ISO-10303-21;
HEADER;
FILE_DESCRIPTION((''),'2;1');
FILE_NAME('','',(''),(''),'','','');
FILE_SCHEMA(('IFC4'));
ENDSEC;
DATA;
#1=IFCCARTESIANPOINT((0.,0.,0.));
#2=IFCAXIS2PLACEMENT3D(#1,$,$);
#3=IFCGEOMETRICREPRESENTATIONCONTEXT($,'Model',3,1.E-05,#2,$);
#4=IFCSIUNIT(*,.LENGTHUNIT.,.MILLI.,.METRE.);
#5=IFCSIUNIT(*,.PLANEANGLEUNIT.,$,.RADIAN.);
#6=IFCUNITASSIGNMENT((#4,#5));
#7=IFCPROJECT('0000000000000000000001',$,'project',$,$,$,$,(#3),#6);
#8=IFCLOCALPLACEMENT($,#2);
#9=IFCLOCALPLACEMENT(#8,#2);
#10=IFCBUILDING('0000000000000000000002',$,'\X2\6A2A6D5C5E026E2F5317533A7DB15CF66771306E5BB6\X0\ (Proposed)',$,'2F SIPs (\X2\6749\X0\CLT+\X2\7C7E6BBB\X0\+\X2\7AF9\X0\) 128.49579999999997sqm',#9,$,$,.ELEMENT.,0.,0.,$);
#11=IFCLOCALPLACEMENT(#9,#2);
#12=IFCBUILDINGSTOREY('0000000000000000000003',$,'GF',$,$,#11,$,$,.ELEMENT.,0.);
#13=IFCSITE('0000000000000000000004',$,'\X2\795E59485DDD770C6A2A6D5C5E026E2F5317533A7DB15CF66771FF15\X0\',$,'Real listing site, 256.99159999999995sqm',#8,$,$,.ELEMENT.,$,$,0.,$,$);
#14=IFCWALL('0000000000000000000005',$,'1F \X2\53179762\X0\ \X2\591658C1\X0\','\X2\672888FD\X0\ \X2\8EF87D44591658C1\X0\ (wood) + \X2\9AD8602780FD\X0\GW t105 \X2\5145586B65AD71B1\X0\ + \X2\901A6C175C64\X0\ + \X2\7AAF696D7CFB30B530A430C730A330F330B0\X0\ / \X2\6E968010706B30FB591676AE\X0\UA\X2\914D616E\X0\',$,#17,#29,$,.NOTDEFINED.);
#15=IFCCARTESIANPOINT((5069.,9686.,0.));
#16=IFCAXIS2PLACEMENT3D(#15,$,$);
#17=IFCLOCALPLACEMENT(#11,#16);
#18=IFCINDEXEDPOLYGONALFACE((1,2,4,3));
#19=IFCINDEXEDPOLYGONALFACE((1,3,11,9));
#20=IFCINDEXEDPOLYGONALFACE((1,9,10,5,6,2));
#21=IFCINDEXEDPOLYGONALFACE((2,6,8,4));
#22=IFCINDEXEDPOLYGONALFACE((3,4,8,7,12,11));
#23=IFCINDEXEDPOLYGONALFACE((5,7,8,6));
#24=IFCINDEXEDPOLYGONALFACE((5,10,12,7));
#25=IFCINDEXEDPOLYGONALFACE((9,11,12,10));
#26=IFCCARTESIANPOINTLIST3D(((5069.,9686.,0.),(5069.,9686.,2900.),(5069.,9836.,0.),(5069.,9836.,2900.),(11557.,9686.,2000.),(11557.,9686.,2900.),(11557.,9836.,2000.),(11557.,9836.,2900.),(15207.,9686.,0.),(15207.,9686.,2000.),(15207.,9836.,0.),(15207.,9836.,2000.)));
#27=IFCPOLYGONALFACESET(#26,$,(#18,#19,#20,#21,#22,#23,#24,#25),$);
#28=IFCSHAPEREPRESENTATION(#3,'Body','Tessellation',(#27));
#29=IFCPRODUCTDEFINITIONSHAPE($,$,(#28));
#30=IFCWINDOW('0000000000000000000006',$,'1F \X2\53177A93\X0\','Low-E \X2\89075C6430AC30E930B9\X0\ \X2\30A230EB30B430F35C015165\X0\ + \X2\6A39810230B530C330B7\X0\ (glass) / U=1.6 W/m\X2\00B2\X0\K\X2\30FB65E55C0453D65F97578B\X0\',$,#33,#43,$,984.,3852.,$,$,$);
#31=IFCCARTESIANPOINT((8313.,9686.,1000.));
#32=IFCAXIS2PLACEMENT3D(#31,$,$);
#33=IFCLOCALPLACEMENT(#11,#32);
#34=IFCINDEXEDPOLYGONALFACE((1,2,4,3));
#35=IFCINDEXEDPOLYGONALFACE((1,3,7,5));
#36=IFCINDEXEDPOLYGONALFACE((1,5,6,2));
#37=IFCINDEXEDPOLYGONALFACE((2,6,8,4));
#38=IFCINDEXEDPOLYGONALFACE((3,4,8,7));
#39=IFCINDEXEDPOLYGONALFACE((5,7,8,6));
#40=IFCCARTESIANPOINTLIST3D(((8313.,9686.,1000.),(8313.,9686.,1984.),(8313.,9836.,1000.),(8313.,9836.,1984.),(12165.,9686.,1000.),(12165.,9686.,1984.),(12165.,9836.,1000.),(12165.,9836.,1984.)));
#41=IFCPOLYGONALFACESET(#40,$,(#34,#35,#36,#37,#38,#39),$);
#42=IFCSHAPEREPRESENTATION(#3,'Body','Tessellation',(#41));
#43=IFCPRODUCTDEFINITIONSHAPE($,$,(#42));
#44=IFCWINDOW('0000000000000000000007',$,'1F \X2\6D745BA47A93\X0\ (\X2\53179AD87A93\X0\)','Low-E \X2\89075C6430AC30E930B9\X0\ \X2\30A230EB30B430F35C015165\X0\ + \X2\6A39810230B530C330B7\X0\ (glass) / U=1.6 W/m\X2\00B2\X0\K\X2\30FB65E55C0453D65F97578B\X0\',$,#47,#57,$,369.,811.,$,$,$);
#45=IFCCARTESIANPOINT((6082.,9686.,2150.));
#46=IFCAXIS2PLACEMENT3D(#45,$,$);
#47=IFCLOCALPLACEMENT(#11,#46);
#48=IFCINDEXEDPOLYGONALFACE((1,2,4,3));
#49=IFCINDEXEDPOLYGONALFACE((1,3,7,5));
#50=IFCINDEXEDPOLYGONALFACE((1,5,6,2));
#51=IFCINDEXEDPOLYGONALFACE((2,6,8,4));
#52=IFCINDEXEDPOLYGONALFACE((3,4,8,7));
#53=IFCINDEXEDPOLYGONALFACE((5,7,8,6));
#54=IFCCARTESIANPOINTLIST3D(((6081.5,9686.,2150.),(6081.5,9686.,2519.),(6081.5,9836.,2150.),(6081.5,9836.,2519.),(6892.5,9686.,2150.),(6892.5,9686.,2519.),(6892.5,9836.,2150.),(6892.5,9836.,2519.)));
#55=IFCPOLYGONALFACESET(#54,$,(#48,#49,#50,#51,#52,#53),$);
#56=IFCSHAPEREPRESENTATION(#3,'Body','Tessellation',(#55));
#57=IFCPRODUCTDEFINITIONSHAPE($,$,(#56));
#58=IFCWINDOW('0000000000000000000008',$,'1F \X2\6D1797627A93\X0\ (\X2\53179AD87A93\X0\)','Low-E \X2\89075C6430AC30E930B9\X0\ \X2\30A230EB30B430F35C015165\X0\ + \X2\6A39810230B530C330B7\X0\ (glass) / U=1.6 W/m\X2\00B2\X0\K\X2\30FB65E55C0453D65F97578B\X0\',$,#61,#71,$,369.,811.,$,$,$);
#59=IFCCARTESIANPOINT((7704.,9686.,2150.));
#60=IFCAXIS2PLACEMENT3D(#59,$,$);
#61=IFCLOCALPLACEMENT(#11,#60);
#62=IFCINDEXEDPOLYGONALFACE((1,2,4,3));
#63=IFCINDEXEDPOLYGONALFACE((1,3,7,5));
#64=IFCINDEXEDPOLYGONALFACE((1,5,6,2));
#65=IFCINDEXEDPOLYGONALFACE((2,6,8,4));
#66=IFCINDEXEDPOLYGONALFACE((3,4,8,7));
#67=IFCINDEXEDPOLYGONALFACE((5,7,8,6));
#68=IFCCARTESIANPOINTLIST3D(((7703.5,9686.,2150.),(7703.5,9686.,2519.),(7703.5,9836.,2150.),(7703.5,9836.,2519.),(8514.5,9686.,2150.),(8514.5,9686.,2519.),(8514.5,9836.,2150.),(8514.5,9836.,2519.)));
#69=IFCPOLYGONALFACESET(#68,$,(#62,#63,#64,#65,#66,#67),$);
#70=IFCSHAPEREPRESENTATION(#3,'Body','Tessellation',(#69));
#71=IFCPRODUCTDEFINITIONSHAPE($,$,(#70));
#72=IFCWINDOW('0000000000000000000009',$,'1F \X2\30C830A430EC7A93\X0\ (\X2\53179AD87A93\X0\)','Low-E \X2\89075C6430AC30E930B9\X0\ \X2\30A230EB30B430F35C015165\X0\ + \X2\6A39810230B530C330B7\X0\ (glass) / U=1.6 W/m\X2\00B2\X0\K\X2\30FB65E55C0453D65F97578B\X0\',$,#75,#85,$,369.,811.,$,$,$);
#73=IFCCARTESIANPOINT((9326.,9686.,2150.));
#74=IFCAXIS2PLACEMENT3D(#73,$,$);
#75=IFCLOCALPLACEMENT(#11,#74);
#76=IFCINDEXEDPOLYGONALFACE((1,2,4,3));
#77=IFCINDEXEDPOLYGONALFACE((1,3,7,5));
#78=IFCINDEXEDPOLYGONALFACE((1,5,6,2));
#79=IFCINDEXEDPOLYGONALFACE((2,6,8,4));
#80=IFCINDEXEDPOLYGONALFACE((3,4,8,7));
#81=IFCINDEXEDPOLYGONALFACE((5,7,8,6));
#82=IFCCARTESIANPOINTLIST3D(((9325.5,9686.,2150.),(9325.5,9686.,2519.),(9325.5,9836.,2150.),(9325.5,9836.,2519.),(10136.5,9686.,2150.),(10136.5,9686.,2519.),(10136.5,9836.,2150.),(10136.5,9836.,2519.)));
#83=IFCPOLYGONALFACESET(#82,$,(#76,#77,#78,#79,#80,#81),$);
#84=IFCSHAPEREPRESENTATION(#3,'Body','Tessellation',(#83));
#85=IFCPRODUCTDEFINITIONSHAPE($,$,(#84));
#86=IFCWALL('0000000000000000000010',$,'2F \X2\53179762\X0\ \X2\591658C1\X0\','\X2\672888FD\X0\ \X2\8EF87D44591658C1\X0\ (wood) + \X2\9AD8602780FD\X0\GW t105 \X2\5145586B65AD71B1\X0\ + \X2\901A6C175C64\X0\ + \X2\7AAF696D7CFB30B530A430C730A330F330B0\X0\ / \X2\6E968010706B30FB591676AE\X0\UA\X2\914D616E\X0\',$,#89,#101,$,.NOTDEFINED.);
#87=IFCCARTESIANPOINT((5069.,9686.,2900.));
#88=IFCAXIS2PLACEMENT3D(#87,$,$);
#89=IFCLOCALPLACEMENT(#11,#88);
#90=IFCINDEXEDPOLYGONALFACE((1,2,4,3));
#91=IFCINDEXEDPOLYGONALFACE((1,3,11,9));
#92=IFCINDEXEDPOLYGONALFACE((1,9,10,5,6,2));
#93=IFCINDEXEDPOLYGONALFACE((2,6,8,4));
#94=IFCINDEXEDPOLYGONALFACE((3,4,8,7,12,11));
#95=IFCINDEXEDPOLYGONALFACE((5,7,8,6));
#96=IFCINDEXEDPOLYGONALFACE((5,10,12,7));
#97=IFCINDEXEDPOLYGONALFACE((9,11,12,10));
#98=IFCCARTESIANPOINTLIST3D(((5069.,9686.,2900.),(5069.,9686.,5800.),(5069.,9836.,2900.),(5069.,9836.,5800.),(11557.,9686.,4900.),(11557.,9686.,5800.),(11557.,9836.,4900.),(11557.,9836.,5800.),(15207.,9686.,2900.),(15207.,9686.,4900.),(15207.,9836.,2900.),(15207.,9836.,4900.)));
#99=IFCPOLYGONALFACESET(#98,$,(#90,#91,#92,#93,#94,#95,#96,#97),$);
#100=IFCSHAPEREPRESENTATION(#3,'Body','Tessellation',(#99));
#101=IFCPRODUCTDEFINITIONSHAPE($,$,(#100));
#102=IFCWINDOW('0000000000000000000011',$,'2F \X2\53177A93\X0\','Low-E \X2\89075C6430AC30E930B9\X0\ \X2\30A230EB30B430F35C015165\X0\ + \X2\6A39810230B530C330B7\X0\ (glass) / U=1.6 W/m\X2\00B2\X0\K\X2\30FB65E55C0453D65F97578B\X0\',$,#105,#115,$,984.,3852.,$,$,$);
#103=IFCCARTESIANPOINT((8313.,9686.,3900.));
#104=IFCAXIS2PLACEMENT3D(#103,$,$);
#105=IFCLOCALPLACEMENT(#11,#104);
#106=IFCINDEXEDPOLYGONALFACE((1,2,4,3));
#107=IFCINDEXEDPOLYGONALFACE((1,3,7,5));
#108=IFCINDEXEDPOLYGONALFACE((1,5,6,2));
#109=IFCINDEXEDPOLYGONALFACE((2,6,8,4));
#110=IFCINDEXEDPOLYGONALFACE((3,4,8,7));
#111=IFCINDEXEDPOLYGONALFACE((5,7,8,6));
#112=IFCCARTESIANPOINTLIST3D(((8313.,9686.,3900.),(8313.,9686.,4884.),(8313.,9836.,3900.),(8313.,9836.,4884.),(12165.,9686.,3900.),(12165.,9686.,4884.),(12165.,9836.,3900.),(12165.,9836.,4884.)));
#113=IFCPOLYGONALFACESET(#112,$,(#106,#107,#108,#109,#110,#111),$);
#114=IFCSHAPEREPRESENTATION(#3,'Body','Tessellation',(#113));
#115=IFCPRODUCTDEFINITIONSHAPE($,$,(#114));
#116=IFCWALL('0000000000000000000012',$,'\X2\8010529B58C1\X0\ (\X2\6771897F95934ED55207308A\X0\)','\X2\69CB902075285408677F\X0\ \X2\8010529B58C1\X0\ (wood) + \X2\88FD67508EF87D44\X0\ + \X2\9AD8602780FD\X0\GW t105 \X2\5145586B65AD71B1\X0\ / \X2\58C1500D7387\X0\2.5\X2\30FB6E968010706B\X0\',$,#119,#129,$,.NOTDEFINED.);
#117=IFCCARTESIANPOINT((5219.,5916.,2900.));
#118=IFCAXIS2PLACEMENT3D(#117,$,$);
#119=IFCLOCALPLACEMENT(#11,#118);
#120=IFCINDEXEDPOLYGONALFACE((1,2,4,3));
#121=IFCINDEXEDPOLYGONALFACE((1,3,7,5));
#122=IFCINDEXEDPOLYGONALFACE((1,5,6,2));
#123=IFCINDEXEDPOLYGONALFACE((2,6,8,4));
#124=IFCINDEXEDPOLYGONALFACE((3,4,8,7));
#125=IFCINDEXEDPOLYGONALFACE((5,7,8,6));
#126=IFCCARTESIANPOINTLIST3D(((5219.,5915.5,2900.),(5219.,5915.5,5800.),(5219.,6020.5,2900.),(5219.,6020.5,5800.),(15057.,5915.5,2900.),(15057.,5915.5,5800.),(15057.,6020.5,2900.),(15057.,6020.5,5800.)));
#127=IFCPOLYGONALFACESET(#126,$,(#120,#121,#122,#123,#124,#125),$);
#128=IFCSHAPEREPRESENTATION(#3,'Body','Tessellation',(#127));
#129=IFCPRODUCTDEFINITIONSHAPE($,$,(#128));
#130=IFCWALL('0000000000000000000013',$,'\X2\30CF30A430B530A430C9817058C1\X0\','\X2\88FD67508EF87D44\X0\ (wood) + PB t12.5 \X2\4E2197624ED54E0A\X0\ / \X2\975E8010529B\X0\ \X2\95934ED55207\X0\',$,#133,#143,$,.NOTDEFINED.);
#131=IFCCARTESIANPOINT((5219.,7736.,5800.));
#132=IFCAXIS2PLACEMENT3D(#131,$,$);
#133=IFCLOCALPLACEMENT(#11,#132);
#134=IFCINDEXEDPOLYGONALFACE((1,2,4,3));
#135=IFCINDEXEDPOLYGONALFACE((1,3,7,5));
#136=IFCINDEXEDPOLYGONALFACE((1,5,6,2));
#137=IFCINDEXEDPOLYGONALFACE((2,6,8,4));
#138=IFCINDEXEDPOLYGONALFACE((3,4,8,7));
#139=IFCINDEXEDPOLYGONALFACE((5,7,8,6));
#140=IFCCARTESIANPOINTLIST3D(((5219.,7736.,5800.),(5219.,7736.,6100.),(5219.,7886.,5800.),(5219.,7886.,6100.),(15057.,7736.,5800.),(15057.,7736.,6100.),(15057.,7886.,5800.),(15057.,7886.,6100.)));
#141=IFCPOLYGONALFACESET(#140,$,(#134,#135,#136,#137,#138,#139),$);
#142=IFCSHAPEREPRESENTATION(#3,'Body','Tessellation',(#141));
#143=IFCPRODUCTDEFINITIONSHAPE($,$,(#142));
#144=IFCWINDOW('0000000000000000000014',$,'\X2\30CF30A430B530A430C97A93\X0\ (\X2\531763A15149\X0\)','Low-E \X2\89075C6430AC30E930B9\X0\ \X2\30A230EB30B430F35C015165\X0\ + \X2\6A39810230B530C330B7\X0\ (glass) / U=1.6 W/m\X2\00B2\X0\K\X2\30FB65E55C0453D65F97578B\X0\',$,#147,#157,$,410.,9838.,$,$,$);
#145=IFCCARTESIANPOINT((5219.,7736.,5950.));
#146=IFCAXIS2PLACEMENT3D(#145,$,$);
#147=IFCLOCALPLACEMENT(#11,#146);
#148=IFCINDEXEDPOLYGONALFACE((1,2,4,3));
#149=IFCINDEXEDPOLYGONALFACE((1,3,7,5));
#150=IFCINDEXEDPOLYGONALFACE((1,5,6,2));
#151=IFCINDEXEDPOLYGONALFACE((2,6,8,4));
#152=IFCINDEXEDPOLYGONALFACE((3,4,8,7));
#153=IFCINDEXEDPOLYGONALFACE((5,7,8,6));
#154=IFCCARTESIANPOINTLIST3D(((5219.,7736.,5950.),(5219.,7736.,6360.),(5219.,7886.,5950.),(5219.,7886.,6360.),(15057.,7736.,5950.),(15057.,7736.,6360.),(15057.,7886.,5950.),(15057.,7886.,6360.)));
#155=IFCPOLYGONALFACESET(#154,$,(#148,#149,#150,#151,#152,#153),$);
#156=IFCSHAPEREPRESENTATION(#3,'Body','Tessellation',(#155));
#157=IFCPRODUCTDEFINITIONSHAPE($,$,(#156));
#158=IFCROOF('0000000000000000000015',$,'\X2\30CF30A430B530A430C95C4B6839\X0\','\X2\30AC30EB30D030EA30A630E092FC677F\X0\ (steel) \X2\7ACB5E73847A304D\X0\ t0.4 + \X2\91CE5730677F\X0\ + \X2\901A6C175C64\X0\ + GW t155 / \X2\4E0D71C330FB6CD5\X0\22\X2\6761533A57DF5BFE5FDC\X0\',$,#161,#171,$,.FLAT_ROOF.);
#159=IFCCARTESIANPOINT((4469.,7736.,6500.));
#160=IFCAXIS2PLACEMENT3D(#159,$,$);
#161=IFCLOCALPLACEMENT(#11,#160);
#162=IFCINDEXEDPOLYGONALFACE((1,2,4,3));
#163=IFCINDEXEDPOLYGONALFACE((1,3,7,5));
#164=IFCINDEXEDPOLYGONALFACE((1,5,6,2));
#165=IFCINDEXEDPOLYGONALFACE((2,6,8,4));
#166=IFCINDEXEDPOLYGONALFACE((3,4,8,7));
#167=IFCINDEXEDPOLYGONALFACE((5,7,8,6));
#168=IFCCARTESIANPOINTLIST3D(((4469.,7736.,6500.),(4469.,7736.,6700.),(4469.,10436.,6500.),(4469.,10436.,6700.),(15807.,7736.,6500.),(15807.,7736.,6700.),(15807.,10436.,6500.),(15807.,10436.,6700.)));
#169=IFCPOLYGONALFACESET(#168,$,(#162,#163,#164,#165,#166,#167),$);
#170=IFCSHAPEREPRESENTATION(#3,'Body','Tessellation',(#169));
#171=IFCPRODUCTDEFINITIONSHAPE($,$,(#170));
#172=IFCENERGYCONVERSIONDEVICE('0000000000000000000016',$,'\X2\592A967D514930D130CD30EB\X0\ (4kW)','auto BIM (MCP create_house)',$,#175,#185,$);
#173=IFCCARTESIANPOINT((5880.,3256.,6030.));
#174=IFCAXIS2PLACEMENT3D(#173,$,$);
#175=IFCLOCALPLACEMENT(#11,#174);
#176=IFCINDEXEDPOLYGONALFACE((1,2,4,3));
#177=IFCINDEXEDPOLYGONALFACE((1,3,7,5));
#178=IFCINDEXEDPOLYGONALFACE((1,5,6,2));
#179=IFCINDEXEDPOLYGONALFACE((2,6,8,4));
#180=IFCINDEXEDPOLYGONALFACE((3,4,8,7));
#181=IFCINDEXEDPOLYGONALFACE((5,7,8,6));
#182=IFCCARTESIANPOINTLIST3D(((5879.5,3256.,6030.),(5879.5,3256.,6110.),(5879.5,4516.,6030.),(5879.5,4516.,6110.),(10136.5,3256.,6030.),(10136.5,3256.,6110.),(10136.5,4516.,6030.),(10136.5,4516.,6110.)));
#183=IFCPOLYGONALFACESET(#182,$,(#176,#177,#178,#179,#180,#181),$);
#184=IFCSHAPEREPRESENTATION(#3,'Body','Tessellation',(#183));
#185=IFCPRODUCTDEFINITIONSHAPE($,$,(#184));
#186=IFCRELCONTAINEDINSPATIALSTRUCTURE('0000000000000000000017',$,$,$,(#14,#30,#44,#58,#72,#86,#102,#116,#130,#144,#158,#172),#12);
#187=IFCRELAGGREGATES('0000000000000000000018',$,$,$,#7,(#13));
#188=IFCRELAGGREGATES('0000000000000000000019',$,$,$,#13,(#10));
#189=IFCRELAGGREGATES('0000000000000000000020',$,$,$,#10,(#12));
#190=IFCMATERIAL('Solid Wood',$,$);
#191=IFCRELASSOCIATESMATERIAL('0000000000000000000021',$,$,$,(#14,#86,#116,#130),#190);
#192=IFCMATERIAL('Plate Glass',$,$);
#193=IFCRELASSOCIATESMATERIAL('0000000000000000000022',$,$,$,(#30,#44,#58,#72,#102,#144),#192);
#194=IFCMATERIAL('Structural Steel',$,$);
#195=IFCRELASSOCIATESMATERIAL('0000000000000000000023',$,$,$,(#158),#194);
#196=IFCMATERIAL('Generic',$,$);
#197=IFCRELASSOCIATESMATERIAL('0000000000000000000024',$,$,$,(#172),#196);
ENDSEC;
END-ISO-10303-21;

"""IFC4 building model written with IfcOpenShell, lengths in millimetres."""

from ifc_helpers import new_model, si_unit, frame, frame_2d, origin, place, context, project, spatial, rectangle, extrude, material, element, fill, save


model = new_model("IFC4")

# Units and contexts
model_context = context("Model", 3, precision=1e-05, world=origin())
ifc_project = project(units=[si_unit("LENGTHUNIT", "METRE", prefix="MILLI"), si_unit("PLANEANGLEUNIT", "RADIAN")], contexts=[model_context])

# Site, building, storey
site_placement = place(None, origin())
site = spatial("IfcSite", under=ifc_project, at=site_placement, Name="神奈川県横浜市港北区綱島東５", ObjectType="Real listing site, 256.99159999999995sqm", CompositionType="ELEMENT", RefElevation=0.0)
building_placement = place(site_placement, origin())
building = spatial("IfcBuilding", under=site, at=building_placement, Name="横浜市港北区綱島東の家 (Proposed)", ObjectType="2F SIPs (杉CLT+籾殻+竹) 128.49579999999997sqm", CompositionType="ELEMENT", ElevationOfRefHeight=0.0, ElevationOfTerrain=0.0)
storey_placement = place(building_placement, origin())
storey = spatial("IfcBuildingStorey", under=building, at=storey_placement, Name="GF", CompositionType="ELEMENT", Elevation=0.0)

# Wall, openings, windows
ifc_material_1 = material(Name="Solid Wood")
wall_1_placement = place(storey_placement, frame((5069.0, 9686.0, 0.0)))
wall_1 = element("IfcWall", 1, at=wall_1_placement, inside=storey, material=ifc_material_1, Name="1F 北面 外壁", Description="木製 軸組外壁 (wood) + 高性能GW t105 充填断熱 + 通気層 + 窯業系サイディング / 準耐火・外皮UA配慮", PredefinedType="NOTDEFINED", context=model_context, shape_type="SweptSolid", body=[
    extrude(rectangle(XDim=10138.0, YDim=150.0, at=frame_2d((5069.0, 75.0))), frame((5069.0, 9686.0, 0.0)), (0.0, 0.0, 1.0), 2900.0),
])
opening_1_placement = place(storey_placement, frame((8313.0, 9686.0, 1000.0)))
opening_1 = element("IfcOpeningElement", 2, at=opening_1_placement, cuts=wall_1, PredefinedType="NOTDEFINED", context=model_context, shape_type="SweptSolid", body=[
    extrude(rectangle(XDim=3852.0, YDim=150.0, at=frame_2d((1926.0, 75.0))), frame((8313.0, 9686.0, 1000.0)), (0.0, 0.0, 1.0), 984.0),
])
opening_2_placement = place(storey_placement, frame((6082.0, 9686.0, 2150.0)))
opening_2 = element("IfcOpeningElement", 3, at=opening_2_placement, cuts=wall_1, PredefinedType="NOTDEFINED", context=model_context, shape_type="SweptSolid", body=[
    extrude(rectangle(XDim=811.0, YDim=150.0, at=frame_2d((405.0, 75.0))), frame((6082.0, 9686.0, 2150.0)), (0.0, 0.0, 1.0), 369.0),
])
opening_3_placement = place(storey_placement, frame((7704.0, 9686.0, 2150.0)))
opening_3 = element("IfcOpeningElement", 4, at=opening_3_placement, cuts=wall_1, PredefinedType="NOTDEFINED", context=model_context, shape_type="SweptSolid", body=[
    extrude(rectangle(XDim=811.0, YDim=150.0, at=frame_2d((405.0, 75.0))), frame((7704.0, 9686.0, 2150.0)), (0.0, 0.0, 1.0), 369.0),
])
opening_4_placement = place(storey_placement, frame((9326.0, 9686.0, 2150.0)))
opening_4 = element("IfcOpeningElement", 5, at=opening_4_placement, cuts=wall_1, PredefinedType="NOTDEFINED", context=model_context, shape_type="SweptSolid", body=[
    extrude(rectangle(XDim=811.0, YDim=150.0, at=frame_2d((405.0, 75.0))), frame((9326.0, 9686.0, 2150.0)), (0.0, 0.0, 1.0), 369.0),
])
ifc_material_2 = material(Name="Plate Glass")
window_1_placement = place(storey_placement, frame((8313.0, 9686.0, 1000.0)))
window_1 = element("IfcWindow", 6, at=window_1_placement, inside=storey, material=ifc_material_2, Name="1F 北窓", Description="Low-E 複層ガラス アルゴン封入 + 樹脂サッシ (glass) / U=1.6 W/m²K・日射取得型", OverallHeight=984.0, OverallWidth=3852.0, context=model_context, shape_type="SweptSolid", body=[
    extrude(rectangle(XDim=3852.0, YDim=150.0, at=frame_2d((1926.0, 75.0))), frame((8313.0, 9686.0, 1000.0)), (0.0, 0.0, 1.0), 984.0),
])
fill(opening_1, window_1)
window_2_placement = place(storey_placement, frame((6082.0, 9686.0, 2150.0)))
window_2 = element("IfcWindow", 7, at=window_2_placement, inside=storey, material=ifc_material_2, Name="1F 浴室窓 (北高窓)", Description="Low-E 複層ガラス アルゴン封入 + 樹脂サッシ (glass) / U=1.6 W/m²K・日射取得型", OverallHeight=369.0, OverallWidth=811.0, context=model_context, shape_type="SweptSolid", body=[
    extrude(rectangle(XDim=811.0, YDim=150.0, at=frame_2d((405.0, 75.0))), frame((6082.0, 9686.0, 2150.0)), (0.0, 0.0, 1.0), 369.0),
])
fill(opening_2, window_2)
window_3_placement = place(storey_placement, frame((7704.0, 9686.0, 2150.0)))
window_3 = element("IfcWindow", 8, at=window_3_placement, inside=storey, material=ifc_material_2, Name="1F 洗面窓 (北高窓)", Description="Low-E 複層ガラス アルゴン封入 + 樹脂サッシ (glass) / U=1.6 W/m²K・日射取得型", OverallHeight=369.0, OverallWidth=811.0, context=model_context, shape_type="SweptSolid", body=[
    extrude(rectangle(XDim=811.0, YDim=150.0, at=frame_2d((405.0, 75.0))), frame((7704.0, 9686.0, 2150.0)), (0.0, 0.0, 1.0), 369.0),
])
fill(opening_3, window_3)
window_4_placement = place(storey_placement, frame((9326.0, 9686.0, 2150.0)))
window_4 = element("IfcWindow", 9, at=window_4_placement, inside=storey, material=ifc_material_2, Name="1F トイレ窓 (北高窓)", Description="Low-E 複層ガラス アルゴン封入 + 樹脂サッシ (glass) / U=1.6 W/m²K・日射取得型", OverallHeight=369.0, OverallWidth=811.0, context=model_context, shape_type="SweptSolid", body=[
    extrude(rectangle(XDim=811.0, YDim=150.0, at=frame_2d((405.0, 75.0))), frame((9326.0, 9686.0, 2150.0)), (0.0, 0.0, 1.0), 369.0),
])
fill(opening_4, window_4)

# Wall, opening, window
wall_2_placement = place(storey_placement, frame((5069.0, 9686.0, 2900.0)))
wall_2 = element("IfcWall", 10, at=wall_2_placement, inside=storey, material=ifc_material_1, Name="2F 北面 外壁", Description="木製 軸組外壁 (wood) + 高性能GW t105 充填断熱 + 通気層 + 窯業系サイディング / 準耐火・外皮UA配慮", PredefinedType="NOTDEFINED", context=model_context, shape_type="SweptSolid", body=[
    extrude(rectangle(XDim=10138.0, YDim=150.0, at=frame_2d((5069.0, 75.0))), frame((5069.0, 9686.0, 2900.0)), (0.0, 0.0, 1.0), 2900.0),
])
opening_5_placement = place(storey_placement, frame((8313.0, 9686.0, 3900.0)))
opening_5 = element("IfcOpeningElement", 11, at=opening_5_placement, cuts=wall_2, PredefinedType="NOTDEFINED", context=model_context, shape_type="SweptSolid", body=[
    extrude(rectangle(XDim=3852.0, YDim=150.0, at=frame_2d((1926.0, 75.0))), frame((8313.0, 9686.0, 3900.0)), (0.0, 0.0, 1.0), 984.0),
])
window_5_placement = place(storey_placement, frame((8313.0, 9686.0, 3900.0)))
window_5 = element("IfcWindow", 12, at=window_5_placement, inside=storey, material=ifc_material_2, Name="2F 北窓", Description="Low-E 複層ガラス アルゴン封入 + 樹脂サッシ (glass) / U=1.6 W/m²K・日射取得型", OverallHeight=984.0, OverallWidth=3852.0, context=model_context, shape_type="SweptSolid", body=[
    extrude(rectangle(XDim=3852.0, YDim=150.0, at=frame_2d((1926.0, 75.0))), frame((8313.0, 9686.0, 3900.0)), (0.0, 0.0, 1.0), 984.0),
])
fill(opening_5, window_5)

# Wall
wall_3_placement = place(storey_placement, frame((5219.0, 5916.0, 2900.0)))
element("IfcWall", 13, at=wall_3_placement, inside=storey, material=ifc_material_1, Name="耐力壁 (東西間仕切り)", Description="構造用合板 耐力壁 (wood) + 製材軸組 + 高性能GW t105 充填断熱 / 壁倍率2.5・準耐火", PredefinedType="NOTDEFINED", context=model_context, shape_type="SweptSolid", body=[
    extrude(rectangle(XDim=9838.0, YDim=105.0, at=frame_2d((4919.0, 52.0))), frame((5219.0, 5916.0, 2900.0)), (0.0, 0.0, 1.0), 2900.0),
])

# Wall, opening, window
wall_4_placement = place(storey_placement, frame((5219.0, 7736.0, 5800.0)))
wall_4 = element("IfcWall", 14, at=wall_4_placement, inside=storey, material=ifc_material_1, Name="ハイサイド腰壁", Description="製材軸組 (wood) + PB t12.5 両面仕上 / 非耐力 間仕切", PredefinedType="NOTDEFINED", context=model_context, shape_type="SweptSolid", body=[
    extrude(rectangle(XDim=9838.0, YDim=150.0, at=frame_2d((4919.0, 75.0))), frame((5219.0, 7736.0, 5800.0)), (0.0, 0.0, 1.0), 700.0),
])
opening_6_placement = place(storey_placement, frame((5219.0, 7736.0, 5950.0)))
opening_6 = element("IfcOpeningElement", 15, at=opening_6_placement, cuts=wall_4, PredefinedType="NOTDEFINED", context=model_context, shape_type="SweptSolid", body=[
    extrude(rectangle(XDim=9838.0, YDim=150.0, at=frame_2d((4919.0, 75.0))), frame((5219.0, 7736.0, 5950.0)), (0.0, 0.0, 1.0), 410.0),
])
window_6_placement = place(storey_placement, frame((5219.0, 7736.0, 5950.0)))
window_6 = element("IfcWindow", 16, at=window_6_placement, inside=storey, material=ifc_material_2, Name="ハイサイド窓 (北採光)", Description="Low-E 複層ガラス アルゴン封入 + 樹脂サッシ (glass) / U=1.6 W/m²K・日射取得型", OverallHeight=410.0, OverallWidth=9838.0, context=model_context, shape_type="SweptSolid", body=[
    extrude(rectangle(XDim=9838.0, YDim=150.0, at=frame_2d((4919.0, 75.0))), frame((5219.0, 7736.0, 5950.0)), (0.0, 0.0, 1.0), 410.0),
])
fill(opening_6, window_6)

# Roof
ifc_material_3 = material(Name="Structural Steel")
roof_placement = place(storey_placement, frame((4469.0, 7736.0, 6500.0)))
element("IfcRoof", 17, at=roof_placement, inside=storey, material=ifc_material_3, Name="ハイサイド屋根", Description="ガルバリウム鋼板 (steel) 立平葺き t0.4 + 野地板 + 通気層 + GW t155 / 不燃・法22条区域対応", PredefinedType="FLAT_ROOF", context=model_context, shape_type="SweptSolid", body=[
    extrude(rectangle(XDim=11338.0, YDim=2700.0, at=frame_2d((5669.0, 1350.0))), frame((4469.0, 7736.0, 6500.0)), (0.0, 0.0, 1.0), 200.0),
])

# Energy conversion device
ifc_material_4 = material(Name="Generic")
energy_conversion_device_placement = place(storey_placement, frame((5880.0, 3256.0, 6030.0)))
element("IfcEnergyConversionDevice", 18, at=energy_conversion_device_placement, inside=storey, material=ifc_material_4, Name="太陽光パネル (4kW)", Description="auto BIM (MCP create_house)", context=model_context, shape_type="SweptSolid", body=[
    extrude(rectangle(XDim=4257.0, YDim=1260.0, at=frame_2d((2128.0, 630.0))), frame((5880.0, 3256.0, 6030.0)), (0.0, 0.0, 1.0), 80.0),
])

save(model, "model.ifc")
